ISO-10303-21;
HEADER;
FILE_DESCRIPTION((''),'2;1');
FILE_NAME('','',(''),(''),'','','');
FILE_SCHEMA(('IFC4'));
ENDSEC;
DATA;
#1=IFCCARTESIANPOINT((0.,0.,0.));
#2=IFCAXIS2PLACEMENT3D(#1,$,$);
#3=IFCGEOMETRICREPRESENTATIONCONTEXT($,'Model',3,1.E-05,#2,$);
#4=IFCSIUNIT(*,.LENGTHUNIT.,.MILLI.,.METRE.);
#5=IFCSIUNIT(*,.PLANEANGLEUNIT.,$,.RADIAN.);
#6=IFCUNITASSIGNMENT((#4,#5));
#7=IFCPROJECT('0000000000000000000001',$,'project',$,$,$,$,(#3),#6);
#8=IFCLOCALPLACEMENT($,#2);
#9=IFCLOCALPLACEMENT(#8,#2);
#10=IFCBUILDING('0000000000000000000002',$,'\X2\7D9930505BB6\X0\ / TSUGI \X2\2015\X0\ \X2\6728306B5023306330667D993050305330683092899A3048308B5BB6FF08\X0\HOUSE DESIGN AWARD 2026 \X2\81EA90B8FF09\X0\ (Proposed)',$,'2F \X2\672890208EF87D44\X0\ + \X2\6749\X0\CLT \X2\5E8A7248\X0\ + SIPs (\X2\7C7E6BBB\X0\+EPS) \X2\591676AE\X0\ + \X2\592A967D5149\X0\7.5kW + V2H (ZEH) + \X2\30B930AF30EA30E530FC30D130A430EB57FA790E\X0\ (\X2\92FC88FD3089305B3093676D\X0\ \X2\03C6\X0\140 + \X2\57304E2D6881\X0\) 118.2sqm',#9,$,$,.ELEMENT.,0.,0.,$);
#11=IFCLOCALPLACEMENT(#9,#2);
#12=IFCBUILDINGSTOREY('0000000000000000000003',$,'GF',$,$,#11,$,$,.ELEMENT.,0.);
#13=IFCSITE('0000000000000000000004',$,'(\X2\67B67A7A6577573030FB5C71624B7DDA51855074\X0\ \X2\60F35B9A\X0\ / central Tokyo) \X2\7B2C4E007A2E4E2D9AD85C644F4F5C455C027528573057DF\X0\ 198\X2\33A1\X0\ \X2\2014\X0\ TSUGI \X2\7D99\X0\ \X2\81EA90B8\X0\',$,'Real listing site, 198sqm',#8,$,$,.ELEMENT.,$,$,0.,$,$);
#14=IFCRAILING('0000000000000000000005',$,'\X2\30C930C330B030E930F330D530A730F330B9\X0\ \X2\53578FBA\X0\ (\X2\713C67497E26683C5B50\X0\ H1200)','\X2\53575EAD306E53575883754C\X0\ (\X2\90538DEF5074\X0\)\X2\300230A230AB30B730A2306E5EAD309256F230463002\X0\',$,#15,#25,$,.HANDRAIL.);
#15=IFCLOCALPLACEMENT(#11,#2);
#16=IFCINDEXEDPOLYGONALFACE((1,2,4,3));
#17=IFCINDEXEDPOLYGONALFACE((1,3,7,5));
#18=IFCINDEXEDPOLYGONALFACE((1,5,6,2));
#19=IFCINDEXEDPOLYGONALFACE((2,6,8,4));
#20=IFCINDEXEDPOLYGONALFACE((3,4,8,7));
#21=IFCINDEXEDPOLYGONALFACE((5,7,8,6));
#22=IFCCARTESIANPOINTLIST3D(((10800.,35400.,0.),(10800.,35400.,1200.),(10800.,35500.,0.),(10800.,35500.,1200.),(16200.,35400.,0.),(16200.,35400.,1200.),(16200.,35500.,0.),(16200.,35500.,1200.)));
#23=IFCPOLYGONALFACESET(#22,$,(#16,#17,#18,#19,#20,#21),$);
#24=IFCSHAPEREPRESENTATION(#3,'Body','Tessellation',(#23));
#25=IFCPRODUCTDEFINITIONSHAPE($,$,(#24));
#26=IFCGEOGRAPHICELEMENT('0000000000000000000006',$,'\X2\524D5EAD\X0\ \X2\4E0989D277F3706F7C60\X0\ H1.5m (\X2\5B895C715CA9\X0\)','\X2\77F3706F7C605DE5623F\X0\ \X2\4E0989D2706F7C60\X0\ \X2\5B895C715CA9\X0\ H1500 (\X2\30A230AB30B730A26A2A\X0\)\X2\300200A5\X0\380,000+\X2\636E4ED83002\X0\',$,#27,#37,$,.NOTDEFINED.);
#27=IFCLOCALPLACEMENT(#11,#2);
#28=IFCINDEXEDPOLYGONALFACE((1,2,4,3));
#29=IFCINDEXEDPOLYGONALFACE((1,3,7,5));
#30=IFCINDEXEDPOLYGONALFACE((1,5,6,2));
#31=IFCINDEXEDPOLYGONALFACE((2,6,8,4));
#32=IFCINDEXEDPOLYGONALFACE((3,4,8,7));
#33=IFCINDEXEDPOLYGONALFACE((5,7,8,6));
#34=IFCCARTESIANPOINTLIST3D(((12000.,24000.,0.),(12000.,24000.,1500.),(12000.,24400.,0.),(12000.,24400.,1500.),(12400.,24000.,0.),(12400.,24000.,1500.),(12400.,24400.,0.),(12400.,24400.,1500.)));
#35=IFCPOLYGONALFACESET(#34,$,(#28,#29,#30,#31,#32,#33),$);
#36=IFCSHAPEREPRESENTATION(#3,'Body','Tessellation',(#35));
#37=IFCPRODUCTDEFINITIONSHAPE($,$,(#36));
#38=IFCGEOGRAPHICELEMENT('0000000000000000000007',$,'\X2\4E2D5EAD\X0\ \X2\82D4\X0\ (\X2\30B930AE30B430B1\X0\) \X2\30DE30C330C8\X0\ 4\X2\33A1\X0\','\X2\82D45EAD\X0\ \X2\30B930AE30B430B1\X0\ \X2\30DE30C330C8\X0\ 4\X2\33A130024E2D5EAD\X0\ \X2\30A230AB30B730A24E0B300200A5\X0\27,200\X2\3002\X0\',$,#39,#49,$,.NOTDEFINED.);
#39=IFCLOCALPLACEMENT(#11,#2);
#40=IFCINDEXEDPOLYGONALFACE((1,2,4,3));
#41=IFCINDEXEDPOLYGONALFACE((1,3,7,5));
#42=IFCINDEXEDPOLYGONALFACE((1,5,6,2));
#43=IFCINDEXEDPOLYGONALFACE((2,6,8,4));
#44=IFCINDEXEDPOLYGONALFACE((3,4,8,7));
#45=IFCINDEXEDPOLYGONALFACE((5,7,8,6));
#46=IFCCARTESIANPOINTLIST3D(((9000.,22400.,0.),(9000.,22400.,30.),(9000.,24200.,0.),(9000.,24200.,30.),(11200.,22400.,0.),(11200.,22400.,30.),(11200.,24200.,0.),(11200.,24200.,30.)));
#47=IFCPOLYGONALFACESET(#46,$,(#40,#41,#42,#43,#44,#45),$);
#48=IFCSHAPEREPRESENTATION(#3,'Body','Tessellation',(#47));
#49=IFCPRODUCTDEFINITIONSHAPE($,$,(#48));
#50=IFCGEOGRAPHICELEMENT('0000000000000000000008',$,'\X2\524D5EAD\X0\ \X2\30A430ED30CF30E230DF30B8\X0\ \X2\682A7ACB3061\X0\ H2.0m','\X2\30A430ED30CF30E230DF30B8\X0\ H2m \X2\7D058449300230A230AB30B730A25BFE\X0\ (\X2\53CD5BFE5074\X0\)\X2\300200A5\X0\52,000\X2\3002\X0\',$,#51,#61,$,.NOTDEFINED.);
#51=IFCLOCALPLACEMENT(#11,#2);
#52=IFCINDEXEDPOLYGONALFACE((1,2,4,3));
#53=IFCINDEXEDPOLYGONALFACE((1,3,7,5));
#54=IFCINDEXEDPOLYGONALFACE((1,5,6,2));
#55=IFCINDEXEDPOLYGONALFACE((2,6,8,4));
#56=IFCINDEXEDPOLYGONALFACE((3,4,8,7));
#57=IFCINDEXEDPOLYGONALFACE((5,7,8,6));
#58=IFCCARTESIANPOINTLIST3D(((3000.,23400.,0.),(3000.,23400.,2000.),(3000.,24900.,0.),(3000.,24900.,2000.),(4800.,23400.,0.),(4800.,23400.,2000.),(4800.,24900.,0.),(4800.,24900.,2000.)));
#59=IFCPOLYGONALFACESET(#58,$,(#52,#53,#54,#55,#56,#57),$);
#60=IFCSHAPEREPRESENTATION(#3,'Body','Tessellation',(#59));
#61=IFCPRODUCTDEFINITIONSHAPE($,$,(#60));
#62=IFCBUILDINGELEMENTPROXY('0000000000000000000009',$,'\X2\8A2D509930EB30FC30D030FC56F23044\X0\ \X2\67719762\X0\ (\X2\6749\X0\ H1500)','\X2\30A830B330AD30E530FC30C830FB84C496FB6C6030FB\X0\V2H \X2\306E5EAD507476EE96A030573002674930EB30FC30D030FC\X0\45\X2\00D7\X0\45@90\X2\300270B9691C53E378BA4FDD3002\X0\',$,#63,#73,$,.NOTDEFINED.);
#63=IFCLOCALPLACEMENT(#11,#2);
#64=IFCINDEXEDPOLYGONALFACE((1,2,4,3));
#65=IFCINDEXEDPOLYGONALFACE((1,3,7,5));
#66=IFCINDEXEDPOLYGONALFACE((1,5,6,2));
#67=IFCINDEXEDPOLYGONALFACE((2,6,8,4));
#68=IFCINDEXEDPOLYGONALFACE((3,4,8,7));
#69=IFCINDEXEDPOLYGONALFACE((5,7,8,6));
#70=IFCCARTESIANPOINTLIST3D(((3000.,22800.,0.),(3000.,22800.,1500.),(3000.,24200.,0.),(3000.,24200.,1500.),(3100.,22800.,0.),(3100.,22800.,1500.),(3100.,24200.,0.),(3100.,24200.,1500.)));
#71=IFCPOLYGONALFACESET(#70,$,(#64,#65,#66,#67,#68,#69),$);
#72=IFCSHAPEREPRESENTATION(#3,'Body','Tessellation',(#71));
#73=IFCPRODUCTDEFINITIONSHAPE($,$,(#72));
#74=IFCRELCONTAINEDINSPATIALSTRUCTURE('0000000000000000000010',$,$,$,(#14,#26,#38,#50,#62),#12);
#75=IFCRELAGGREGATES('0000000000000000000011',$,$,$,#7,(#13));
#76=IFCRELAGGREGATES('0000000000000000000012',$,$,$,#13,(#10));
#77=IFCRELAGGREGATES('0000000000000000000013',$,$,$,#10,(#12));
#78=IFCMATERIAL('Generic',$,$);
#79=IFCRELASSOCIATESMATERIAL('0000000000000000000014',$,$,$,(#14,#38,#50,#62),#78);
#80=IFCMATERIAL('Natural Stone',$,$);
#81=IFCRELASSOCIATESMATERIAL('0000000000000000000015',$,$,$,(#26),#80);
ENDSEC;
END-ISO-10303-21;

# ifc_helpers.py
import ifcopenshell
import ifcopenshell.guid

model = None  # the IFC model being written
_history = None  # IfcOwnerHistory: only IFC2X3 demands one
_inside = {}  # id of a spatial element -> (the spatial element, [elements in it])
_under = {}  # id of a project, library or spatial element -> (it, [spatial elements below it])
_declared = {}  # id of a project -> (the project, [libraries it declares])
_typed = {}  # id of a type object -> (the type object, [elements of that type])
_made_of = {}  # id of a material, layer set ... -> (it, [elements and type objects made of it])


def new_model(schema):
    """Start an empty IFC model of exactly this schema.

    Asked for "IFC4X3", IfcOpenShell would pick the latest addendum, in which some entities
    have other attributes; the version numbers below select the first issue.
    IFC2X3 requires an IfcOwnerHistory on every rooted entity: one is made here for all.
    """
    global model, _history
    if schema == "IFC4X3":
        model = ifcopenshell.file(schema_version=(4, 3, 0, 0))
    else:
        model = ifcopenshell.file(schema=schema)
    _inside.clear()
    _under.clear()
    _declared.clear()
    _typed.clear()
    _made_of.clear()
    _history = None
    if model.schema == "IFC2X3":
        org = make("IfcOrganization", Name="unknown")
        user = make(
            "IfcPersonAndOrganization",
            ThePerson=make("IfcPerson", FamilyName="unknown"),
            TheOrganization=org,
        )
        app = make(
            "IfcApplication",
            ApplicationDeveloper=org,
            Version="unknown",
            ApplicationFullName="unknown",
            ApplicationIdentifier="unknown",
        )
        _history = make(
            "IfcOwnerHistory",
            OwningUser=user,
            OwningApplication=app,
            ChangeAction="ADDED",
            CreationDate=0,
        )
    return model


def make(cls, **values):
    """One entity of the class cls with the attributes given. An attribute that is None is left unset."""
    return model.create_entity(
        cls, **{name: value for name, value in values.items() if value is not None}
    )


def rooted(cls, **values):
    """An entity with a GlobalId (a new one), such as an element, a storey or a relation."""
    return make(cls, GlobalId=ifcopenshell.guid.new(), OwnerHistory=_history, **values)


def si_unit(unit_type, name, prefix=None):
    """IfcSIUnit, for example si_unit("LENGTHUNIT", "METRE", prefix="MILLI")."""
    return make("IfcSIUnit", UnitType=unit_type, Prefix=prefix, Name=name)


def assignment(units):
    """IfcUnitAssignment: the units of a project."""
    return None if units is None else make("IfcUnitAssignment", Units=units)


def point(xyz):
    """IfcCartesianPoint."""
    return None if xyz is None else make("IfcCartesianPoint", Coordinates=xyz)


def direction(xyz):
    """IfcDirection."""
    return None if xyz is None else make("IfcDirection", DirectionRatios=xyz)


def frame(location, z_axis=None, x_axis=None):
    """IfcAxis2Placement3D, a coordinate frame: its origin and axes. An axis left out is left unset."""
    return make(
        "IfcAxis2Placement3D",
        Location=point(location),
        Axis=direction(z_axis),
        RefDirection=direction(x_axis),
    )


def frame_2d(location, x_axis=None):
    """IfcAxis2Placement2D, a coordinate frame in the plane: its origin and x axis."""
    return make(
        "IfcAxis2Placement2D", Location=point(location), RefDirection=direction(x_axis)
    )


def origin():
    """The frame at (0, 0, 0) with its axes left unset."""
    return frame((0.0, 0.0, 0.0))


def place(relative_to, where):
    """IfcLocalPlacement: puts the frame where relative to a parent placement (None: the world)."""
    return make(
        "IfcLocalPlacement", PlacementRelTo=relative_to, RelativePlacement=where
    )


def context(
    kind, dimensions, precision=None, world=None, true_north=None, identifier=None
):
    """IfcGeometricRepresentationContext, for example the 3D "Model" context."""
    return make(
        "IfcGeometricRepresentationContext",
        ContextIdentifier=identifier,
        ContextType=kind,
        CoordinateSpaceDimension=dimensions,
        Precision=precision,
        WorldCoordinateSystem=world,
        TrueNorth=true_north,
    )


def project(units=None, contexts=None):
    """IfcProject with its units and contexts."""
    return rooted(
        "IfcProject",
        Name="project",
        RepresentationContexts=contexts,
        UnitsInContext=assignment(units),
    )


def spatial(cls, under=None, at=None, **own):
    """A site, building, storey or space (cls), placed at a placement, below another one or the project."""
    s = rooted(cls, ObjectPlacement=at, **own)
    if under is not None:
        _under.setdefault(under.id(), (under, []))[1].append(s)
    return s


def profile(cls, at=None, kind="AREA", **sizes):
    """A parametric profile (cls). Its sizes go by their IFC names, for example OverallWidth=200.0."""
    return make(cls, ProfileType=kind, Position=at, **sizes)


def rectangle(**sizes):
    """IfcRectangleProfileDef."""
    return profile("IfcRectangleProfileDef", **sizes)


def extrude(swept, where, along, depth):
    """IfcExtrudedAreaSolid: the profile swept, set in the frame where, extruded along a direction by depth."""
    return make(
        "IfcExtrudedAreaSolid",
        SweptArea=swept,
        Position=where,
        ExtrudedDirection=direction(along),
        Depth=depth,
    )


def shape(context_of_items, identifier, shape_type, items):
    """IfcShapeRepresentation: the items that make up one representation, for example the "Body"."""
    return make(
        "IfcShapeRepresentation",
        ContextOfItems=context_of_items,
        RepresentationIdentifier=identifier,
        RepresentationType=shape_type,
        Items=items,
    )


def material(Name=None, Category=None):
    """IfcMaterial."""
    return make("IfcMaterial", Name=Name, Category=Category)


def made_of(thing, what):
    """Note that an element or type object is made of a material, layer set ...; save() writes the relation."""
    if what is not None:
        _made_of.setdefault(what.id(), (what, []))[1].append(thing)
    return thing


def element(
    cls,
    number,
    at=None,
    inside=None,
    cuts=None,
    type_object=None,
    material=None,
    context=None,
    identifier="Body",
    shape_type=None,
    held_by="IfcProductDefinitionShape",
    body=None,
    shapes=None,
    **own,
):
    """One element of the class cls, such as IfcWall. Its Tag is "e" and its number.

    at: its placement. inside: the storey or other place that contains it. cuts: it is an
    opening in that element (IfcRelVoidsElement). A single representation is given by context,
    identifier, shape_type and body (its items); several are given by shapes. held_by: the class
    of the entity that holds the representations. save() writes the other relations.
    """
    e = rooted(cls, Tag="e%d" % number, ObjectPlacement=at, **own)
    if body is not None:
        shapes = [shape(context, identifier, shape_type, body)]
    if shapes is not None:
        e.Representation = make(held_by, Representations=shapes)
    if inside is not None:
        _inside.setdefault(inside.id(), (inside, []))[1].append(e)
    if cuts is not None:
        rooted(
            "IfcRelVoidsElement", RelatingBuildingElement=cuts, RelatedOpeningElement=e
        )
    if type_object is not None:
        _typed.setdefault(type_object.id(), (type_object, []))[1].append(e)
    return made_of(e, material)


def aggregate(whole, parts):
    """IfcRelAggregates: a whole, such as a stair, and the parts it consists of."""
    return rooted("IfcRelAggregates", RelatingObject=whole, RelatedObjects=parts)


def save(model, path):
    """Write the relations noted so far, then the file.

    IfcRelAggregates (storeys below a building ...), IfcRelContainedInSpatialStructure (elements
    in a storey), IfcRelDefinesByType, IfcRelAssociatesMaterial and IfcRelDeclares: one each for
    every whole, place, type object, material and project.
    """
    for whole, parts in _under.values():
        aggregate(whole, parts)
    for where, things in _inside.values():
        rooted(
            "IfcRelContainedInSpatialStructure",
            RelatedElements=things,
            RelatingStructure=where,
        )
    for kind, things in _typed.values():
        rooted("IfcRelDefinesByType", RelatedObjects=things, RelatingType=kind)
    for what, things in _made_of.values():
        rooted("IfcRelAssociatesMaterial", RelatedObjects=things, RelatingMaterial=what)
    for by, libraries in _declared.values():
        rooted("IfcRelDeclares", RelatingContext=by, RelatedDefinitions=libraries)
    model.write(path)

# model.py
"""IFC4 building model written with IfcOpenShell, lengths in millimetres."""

from ifc_helpers import new_model, si_unit, frame, frame_2d, origin, place, context, project, spatial, rectangle, extrude, material, element, save


model = new_model("IFC4")

# Units and contexts
model_context = context("Model", 3, precision=1e-05, world=origin())
ifc_project = project(units=[si_unit("LENGTHUNIT", "METRE", prefix="MILLI"), si_unit("PLANEANGLEUNIT", "RADIAN")], contexts=[model_context])

# Site, building, storey
site_placement = place(None, origin())
site = spatial("IfcSite", under=ifc_project, at=site_placement, Name="(架空敷地・山手線内側 想定 / central Tokyo) 第一種中高層住居専用地域 198㎡ — TSUGI 継 自邸", ObjectType="Real listing site, 198sqm", CompositionType="ELEMENT", RefElevation=0.0)
building_placement = place(site_placement, origin())
building = spatial("IfcBuilding", under=site, at=building_placement, Name="継ぐ家 / TSUGI ― 木に倣って継ぐことを覚える家（HOUSE DESIGN AWARD 2026 自邸） (Proposed)", ObjectType="2F 木造軸組 + 杉CLT 床版 + SIPs (籾殻+EPS) 外皮 + 太陽光7.5kW + V2H (ZEH) + スクリューパイル基礎 (鋼製らせん杭 φ140 + 地中梁) 118.2sqm", CompositionType="ELEMENT", ElevationOfRefHeight=0.0, ElevationOfTerrain=0.0)
storey_placement = place(building_placement, origin())
storey = spatial("IfcBuildingStorey", under=building, at=storey_placement, Name="GF", CompositionType="ELEMENT", Elevation=0.0)

# Shared definitions
ifc_material_1 = material(Name="Generic")

# Railing
railing_1_placement = place(storey_placement, frame((5400.0, 17700.0, 0.0)))
element("IfcRailing", 1, at=railing_1_placement, inside=storey, material=ifc_material_1, Name="ドッグランフェンス 南辺 (焼杉縦格子 H1200)", Description="南庭の南境界 (道路側)。アカシアの庭を囲う。", PredefinedType="HANDRAIL", context=model_context, shape_type="SweptSolid", body=[
    extrude(rectangle(XDim=5400.0, YDim=100.0, at=frame_2d((2700.0, 50.0))), frame((5400.0, 17700.0, 0.0)), (0.0, 0.0, 1.0), 1200.0),
])

# Geographic elements
ifc_material_2 = material(Name="Natural Stone")
geographic_element_1_placement = place(storey_placement, frame((6000.0, 12000.0, 0.0)))
element("IfcGeographicElement", 2, at=geographic_element_1_placement, inside=storey, material=ifc_material_2, Name="前庭 三角石灯籠 H1.5m (安山岩)", Description="石灯籠工房 三角灯籠 安山岩 H1500 (アカシア横)。¥380,000+据付。", PredefinedType="NOTDEFINED", context=model_context, shape_type="SweptSolid", body=[
    extrude(rectangle(XDim=400.0, YDim=400.0, at=frame_2d((200.0, 200.0))), frame((6000.0, 12000.0, 0.0)), (0.0, 0.0, 1.0), 1500.0),
])
geographic_element_2_placement = place(storey_placement, frame((4500.0, 11200.0, 0.0)))
element("IfcGeographicElement", 3, at=geographic_element_2_placement, inside=storey, material=ifc_material_1, Name="中庭 苔 (スギゴケ) マット 4㎡", Description="苔庭 スギゴケ マット 4㎡。中庭 アカシア下。¥27,200。", PredefinedType="NOTDEFINED", context=model_context, shape_type="SweptSolid", body=[
    extrude(rectangle(XDim=2200.0, YDim=1800.0, at=frame_2d((1100.0, 900.0))), frame((4500.0, 11200.0, 0.0)), (0.0, 0.0, 1.0), 30.0),
])
geographic_element_3_placement = place(storey_placement, frame((1500.0, 11700.0, 0.0)))
element("IfcGeographicElement", 4, at=geographic_element_3_placement, inside=storey, material=ifc_material_1, Name="前庭 イロハモミジ 株立ち H2.0m", Description="イロハモミジ H2m 紅葉。アカシア対 (反対側)。¥52,000。", PredefinedType="NOTDEFINED", context=model_context, shape_type="SweptSolid", body=[
    extrude(rectangle(XDim=1800.0, YDim=1500.0, at=frame_2d((900.0, 750.0))), frame((1500.0, 11700.0, 0.0)), (0.0, 0.0, 1.0), 2000.0),
])

# Building element proxy
proxy_1_placement = place(storey_placement, frame((1500.0, 11400.0, 0.0)))
element("IfcBuildingElementProxy", 5, at=proxy_1_placement, inside=storey, material=ifc_material_1, Name="設備ルーバー囲い 東面 (杉 H1500)", Description="エコキュート・蓄電池・V2H の庭側目隠し。杉ルーバー45×45@90。点検口確保。", PredefinedType="NOTDEFINED", context=model_context, shape_type="SweptSolid", body=[
    extrude(rectangle(XDim=100.0, YDim=1400.0, at=frame_2d((50.0, 700.0))), frame((1500.0, 11400.0, 0.0)), (0.0, 0.0, 1.0), 1500.0),
])

save(model, "model.ifc")
